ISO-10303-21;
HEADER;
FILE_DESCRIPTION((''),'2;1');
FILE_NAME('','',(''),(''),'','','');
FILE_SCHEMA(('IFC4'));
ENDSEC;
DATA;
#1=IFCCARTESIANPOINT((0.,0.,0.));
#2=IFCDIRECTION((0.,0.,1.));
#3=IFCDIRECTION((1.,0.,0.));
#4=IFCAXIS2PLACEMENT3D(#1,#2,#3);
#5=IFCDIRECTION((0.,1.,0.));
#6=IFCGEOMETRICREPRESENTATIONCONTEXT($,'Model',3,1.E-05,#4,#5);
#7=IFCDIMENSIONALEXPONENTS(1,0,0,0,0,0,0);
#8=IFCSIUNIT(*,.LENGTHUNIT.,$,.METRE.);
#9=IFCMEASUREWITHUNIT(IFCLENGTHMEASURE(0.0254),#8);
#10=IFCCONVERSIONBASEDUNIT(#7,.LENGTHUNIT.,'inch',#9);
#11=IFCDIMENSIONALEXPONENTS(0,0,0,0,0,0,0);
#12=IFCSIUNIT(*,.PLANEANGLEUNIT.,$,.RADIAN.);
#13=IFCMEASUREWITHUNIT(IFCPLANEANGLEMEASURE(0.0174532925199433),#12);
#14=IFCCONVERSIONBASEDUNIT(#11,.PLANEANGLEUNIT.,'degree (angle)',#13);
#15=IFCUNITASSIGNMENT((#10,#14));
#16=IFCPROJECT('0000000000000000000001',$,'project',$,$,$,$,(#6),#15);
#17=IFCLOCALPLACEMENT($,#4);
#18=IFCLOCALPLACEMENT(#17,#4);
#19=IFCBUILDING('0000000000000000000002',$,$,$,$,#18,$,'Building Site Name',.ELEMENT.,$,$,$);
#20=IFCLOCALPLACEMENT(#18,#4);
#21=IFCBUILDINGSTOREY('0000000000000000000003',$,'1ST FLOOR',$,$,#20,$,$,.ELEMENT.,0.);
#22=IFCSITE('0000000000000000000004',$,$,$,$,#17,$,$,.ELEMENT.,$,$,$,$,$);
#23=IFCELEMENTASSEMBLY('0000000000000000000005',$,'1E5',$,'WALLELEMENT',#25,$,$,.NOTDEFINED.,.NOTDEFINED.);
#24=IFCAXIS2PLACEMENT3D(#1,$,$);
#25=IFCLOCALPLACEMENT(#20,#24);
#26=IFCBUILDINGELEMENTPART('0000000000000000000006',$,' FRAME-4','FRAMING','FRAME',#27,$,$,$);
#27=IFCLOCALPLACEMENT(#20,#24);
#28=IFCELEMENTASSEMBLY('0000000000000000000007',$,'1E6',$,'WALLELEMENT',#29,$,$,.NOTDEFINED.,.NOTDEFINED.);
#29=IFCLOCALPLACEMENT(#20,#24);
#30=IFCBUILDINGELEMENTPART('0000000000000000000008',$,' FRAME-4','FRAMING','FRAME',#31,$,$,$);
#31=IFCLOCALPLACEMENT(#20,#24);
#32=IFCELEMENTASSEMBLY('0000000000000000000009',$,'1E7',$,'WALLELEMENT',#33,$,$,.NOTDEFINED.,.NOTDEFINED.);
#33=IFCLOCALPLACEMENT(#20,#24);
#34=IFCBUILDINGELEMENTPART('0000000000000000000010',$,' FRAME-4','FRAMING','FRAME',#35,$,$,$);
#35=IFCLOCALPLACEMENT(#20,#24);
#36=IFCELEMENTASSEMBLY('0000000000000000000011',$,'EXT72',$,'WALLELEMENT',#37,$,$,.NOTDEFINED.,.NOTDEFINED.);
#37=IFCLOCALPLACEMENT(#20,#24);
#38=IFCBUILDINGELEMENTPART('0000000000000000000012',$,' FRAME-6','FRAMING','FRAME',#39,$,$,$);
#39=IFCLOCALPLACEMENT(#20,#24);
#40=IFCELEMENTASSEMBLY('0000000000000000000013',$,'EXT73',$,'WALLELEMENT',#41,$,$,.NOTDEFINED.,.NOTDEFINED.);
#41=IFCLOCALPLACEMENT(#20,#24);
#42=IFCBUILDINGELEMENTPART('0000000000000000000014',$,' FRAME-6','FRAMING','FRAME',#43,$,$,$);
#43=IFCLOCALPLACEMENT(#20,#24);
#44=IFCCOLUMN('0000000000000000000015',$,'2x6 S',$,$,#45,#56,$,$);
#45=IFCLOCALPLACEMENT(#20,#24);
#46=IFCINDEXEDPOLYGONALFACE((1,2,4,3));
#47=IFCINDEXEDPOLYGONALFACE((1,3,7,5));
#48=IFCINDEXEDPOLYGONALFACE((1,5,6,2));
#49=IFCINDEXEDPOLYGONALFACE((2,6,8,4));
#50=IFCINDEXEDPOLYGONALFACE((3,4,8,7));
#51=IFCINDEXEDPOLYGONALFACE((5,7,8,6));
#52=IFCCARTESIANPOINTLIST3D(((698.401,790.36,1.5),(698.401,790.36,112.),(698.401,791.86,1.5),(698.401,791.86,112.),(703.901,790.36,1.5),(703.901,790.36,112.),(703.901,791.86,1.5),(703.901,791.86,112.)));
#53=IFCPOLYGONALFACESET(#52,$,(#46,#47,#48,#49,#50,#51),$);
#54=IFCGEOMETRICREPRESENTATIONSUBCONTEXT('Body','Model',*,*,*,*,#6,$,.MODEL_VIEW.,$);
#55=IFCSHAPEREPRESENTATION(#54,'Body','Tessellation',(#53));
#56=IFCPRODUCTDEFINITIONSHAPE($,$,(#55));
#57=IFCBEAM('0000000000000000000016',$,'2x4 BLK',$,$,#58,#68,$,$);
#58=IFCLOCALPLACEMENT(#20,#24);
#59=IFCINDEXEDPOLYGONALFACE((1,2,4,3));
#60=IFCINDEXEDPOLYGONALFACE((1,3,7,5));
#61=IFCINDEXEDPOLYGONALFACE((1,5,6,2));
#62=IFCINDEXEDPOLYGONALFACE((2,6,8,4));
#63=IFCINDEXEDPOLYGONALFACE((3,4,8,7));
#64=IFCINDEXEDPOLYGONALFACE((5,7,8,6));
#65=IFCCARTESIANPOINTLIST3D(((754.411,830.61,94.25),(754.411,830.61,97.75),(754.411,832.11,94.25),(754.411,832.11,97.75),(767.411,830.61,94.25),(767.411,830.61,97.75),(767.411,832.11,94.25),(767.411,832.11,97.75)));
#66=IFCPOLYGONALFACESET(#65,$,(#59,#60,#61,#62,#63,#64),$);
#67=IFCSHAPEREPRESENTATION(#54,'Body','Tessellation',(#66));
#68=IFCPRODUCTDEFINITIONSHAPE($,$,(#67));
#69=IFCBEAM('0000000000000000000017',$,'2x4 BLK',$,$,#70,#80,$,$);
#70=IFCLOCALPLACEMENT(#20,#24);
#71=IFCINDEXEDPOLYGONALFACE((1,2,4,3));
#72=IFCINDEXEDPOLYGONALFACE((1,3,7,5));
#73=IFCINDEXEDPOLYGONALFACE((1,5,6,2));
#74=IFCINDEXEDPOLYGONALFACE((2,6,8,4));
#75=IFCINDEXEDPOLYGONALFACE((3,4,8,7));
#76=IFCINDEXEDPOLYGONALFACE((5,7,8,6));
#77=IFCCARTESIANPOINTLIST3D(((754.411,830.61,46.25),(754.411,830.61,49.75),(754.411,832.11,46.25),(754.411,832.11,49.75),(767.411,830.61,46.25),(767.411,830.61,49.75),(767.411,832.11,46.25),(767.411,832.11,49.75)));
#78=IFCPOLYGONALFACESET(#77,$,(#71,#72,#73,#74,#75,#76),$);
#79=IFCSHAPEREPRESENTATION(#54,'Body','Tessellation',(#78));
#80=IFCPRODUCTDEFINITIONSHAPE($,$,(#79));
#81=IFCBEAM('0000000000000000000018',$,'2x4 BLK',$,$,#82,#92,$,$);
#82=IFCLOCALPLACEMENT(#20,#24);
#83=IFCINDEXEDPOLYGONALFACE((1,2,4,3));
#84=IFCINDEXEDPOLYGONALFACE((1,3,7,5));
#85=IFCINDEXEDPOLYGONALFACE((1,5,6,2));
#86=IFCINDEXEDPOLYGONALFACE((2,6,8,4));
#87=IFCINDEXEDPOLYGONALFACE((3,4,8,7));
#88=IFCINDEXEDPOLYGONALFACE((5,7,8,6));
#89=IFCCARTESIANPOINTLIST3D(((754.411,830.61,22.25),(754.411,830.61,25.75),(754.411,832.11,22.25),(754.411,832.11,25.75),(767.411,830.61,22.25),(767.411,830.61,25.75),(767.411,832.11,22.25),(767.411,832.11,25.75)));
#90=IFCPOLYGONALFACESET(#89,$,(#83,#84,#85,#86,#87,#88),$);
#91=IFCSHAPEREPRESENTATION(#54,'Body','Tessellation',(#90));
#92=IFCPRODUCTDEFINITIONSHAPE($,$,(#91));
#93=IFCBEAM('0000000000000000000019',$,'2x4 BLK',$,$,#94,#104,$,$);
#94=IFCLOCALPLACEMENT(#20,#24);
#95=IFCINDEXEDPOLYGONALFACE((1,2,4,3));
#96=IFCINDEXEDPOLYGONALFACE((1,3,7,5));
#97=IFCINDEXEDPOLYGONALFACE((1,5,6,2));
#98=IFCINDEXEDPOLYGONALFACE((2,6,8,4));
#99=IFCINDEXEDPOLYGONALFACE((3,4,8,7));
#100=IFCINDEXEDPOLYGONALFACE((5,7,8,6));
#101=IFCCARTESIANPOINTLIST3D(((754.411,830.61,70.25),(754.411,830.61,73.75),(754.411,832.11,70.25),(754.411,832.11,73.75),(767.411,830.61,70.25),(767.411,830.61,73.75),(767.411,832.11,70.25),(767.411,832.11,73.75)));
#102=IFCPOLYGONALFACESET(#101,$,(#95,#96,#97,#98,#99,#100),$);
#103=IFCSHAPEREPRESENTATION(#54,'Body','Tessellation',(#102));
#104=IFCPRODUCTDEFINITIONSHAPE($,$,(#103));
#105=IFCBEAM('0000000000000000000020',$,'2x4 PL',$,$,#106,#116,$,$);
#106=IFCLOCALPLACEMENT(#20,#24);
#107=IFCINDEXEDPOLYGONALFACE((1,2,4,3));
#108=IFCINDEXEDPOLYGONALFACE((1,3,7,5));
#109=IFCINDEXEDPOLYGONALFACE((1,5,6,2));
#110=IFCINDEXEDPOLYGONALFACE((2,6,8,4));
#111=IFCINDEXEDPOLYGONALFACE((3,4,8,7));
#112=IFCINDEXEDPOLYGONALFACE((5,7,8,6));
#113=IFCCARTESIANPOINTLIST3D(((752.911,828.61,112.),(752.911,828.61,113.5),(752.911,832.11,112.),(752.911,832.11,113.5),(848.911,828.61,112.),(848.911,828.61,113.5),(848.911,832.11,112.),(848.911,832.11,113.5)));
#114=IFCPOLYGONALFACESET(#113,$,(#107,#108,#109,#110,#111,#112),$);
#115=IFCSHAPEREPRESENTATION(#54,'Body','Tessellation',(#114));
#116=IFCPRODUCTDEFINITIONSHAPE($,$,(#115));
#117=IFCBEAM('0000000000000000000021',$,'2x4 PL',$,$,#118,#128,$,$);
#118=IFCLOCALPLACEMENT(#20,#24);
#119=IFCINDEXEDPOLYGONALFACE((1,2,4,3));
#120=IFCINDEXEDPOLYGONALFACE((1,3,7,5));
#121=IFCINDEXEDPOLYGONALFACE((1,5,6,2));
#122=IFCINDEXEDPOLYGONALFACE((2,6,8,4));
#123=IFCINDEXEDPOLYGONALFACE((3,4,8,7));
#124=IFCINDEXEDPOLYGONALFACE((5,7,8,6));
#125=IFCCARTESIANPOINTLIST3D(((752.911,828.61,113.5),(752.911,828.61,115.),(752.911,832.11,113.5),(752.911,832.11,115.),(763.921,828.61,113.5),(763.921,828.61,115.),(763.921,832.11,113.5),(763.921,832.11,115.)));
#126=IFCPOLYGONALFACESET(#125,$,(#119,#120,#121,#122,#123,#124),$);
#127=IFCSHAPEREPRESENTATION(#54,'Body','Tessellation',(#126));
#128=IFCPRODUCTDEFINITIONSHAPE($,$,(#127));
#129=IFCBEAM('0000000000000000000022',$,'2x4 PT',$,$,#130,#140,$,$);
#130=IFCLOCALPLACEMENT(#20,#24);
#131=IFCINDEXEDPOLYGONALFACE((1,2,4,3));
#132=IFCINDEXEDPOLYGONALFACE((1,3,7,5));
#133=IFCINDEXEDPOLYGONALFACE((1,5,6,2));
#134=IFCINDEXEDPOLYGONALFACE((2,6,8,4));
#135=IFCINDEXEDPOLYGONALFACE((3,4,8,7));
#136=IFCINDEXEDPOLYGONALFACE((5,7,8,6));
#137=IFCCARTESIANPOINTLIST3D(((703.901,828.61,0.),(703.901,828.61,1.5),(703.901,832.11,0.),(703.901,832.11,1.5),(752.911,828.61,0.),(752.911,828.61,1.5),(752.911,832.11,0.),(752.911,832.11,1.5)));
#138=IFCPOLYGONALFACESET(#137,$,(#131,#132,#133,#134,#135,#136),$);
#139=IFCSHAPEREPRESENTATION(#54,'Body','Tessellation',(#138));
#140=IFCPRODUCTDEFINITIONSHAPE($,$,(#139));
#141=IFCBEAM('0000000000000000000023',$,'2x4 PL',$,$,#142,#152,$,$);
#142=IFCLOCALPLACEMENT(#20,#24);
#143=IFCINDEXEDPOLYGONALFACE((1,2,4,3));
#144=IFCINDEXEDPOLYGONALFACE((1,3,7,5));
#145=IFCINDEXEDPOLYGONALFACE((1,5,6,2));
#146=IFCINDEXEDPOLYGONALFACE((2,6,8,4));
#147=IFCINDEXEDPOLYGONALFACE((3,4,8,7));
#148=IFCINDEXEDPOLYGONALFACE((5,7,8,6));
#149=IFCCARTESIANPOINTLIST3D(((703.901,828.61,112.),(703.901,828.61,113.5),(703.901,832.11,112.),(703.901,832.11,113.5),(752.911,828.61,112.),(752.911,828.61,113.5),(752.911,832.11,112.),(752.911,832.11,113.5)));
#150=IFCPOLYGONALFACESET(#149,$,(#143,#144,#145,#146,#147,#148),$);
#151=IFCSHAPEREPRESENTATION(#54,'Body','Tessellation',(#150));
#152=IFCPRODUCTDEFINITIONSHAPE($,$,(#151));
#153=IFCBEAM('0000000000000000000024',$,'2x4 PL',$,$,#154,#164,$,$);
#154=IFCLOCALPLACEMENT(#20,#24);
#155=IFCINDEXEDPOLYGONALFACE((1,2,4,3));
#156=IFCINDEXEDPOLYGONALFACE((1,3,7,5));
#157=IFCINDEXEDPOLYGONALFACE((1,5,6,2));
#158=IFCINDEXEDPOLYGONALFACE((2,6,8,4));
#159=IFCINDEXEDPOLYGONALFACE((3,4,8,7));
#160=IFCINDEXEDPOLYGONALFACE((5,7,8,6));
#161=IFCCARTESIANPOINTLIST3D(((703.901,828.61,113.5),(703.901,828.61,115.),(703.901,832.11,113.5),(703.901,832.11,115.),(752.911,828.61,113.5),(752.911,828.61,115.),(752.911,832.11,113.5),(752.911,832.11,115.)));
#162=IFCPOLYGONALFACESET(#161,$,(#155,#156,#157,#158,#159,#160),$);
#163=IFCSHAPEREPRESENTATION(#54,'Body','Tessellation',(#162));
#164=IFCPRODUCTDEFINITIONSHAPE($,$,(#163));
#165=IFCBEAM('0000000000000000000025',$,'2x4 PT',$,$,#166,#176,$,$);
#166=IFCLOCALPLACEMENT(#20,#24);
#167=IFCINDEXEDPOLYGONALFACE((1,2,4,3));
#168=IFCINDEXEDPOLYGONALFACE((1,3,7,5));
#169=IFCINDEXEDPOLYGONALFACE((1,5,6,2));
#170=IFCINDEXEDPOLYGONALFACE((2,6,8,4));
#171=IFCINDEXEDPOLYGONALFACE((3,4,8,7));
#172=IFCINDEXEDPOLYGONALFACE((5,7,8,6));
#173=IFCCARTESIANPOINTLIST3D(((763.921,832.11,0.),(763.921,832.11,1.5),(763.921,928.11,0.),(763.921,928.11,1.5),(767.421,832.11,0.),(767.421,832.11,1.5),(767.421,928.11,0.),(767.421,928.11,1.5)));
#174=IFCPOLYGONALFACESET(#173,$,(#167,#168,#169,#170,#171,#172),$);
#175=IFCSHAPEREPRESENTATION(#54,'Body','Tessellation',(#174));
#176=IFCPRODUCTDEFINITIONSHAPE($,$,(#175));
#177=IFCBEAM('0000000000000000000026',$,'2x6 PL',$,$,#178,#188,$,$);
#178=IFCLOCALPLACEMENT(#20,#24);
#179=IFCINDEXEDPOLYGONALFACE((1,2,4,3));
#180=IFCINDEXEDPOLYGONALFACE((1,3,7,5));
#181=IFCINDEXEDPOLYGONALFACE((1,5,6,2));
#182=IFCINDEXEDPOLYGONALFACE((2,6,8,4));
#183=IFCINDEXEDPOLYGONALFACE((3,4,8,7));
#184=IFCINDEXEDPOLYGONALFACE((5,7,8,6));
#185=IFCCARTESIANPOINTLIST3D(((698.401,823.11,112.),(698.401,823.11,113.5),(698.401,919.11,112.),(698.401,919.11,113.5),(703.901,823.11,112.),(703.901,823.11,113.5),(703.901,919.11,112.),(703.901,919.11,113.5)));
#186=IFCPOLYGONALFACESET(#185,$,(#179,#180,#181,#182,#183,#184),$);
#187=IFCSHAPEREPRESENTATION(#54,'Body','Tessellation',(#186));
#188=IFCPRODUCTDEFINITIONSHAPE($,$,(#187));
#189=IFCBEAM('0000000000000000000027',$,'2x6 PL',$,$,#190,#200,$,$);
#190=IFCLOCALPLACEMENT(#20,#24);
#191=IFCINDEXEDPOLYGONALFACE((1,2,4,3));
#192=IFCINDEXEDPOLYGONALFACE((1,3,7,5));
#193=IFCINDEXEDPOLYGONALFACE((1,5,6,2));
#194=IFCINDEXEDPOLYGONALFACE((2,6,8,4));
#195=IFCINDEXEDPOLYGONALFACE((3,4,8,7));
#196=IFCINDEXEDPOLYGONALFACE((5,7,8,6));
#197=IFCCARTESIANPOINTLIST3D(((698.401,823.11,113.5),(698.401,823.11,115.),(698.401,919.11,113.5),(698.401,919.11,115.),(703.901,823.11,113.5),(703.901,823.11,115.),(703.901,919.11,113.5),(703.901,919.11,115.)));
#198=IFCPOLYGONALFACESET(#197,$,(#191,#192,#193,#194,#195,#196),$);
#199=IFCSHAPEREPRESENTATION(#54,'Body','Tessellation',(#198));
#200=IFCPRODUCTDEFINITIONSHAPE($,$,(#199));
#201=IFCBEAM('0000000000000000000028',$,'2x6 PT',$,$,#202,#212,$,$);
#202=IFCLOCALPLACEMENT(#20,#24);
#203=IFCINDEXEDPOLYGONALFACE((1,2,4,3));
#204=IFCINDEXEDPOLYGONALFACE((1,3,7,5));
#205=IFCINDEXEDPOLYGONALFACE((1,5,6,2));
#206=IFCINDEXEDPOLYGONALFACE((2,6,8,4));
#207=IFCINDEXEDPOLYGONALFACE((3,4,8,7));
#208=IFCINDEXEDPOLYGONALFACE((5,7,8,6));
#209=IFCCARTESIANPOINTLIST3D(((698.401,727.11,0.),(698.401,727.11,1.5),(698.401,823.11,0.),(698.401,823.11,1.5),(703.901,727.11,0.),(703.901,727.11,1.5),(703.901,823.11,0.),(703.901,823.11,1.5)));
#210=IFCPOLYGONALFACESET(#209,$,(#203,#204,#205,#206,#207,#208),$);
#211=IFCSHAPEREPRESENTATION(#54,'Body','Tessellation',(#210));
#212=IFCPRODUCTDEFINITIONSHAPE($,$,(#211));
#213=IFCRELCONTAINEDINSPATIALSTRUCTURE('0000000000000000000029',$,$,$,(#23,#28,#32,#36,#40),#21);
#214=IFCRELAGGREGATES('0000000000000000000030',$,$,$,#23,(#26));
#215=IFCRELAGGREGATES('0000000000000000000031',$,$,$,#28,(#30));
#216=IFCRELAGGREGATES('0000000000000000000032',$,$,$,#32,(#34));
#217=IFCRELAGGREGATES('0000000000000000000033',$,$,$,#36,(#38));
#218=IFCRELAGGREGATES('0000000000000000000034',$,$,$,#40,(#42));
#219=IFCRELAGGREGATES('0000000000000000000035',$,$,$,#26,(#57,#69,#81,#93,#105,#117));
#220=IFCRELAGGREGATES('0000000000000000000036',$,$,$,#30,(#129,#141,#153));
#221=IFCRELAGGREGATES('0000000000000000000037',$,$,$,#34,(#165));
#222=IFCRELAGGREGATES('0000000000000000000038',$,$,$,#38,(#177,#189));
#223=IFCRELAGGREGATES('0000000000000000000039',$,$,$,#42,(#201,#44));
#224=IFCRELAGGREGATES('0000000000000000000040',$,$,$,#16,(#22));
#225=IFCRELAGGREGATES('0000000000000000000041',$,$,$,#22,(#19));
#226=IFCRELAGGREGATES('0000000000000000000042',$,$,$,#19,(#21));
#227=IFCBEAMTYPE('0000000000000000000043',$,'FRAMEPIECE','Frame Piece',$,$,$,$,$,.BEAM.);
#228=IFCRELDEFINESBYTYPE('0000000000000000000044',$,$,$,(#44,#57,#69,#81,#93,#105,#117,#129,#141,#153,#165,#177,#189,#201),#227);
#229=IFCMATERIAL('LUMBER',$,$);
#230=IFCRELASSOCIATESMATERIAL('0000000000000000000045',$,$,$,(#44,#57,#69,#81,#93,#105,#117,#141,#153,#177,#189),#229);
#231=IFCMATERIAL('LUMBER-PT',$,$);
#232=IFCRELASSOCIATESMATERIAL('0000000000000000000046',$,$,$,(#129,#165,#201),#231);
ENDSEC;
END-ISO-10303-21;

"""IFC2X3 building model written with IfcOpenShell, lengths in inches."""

from ifc_helpers import new_model, entity, si_unit, converted_unit, direction, frame, frame_2d, origin_with_axes, place, context, subcontext, project, spatial, rectangle, extrude, material, type_object, element, aggregate, save


model = new_model("IFC2X3")

# Units and contexts
model_context = context("Model", 3, precision=1e-05, world=origin_with_axes(), true_north=direction((0.0, 1.0, 0.0)))
body_context = subcontext(model_context, "Body", "Model", "MODEL_VIEW")
ifc_project = project(units=[converted_unit("LENGTHUNIT", "inch", entity("IfcLengthMeasure", 0.0254), si_unit("LENGTHUNIT", "METRE"), dimensions=[1, 0, 0, 0, 0, 0, 0]), converted_unit("PLANEANGLEUNIT", "degree (angle)", entity("IfcPlaneAngleMeasure", 0.0174532925199433), si_unit("PLANEANGLEUNIT", "RADIAN"), dimensions=[0, 0, 0, 0, 0, 0, 0])], contexts=[model_context])

# Site, building, storey
site_placement = place(None, origin_with_axes())
site = spatial("IfcSite", under=ifc_project, at=site_placement, CompositionType="ELEMENT")
building_placement = place(site_placement, origin_with_axes())
building = spatial("IfcBuilding", under=site, at=building_placement, LongName="Building Site Name", CompositionType="ELEMENT")
storey_placement = place(building_placement, origin_with_axes())
storey = spatial("IfcBuildingStorey", under=building, at=storey_placement, Name="1ST FLOOR", CompositionType="ELEMENT", Elevation=0.0)

# Element assembly, building element part
assembly_1_placement = place(storey_placement, origin_with_axes())
assembly_1 = element("IfcElementAssembly", 1, at=assembly_1_placement, inside=storey, Name="1E5", ObjectType="WALLELEMENT", AssemblyPlace="NOTDEFINED", PredefinedType="NOTDEFINED")
building_element_part_1 = element("IfcBuildingElementPart", 2, Name=" FRAME-4", Description="FRAMING", ObjectType="FRAME")
aggregate(assembly_1, [building_element_part_1])
ifc_material_1 = material(Name="LUMBER")
beam_type = type_object("IfcBeamType", Name="FRAMEPIECE", Description="Frame Piece", PredefinedType="BEAM")

# Element assemblies, building element parts, column
assembly_2_placement = place(storey_placement, origin_with_axes())
assembly_2 = element("IfcElementAssembly", 3, at=assembly_2_placement, inside=storey, Name="1E6", ObjectType="WALLELEMENT", AssemblyPlace="NOTDEFINED", PredefinedType="NOTDEFINED")
building_element_part_2 = element("IfcBuildingElementPart", 4, Name=" FRAME-4", Description="FRAMING", ObjectType="FRAME")
aggregate(assembly_2, [building_element_part_2])
assembly_3_placement = place(storey_placement, origin_with_axes())
assembly_3 = element("IfcElementAssembly", 5, at=assembly_3_placement, inside=storey, Name="1E7", ObjectType="WALLELEMENT", AssemblyPlace="NOTDEFINED", PredefinedType="NOTDEFINED")
building_element_part_3 = element("IfcBuildingElementPart", 6, Name=" FRAME-4", Description="FRAMING", ObjectType="FRAME")
aggregate(assembly_3, [building_element_part_3])
assembly_4_placement = place(storey_placement, origin_with_axes())
assembly_4 = element("IfcElementAssembly", 7, at=assembly_4_placement, inside=storey, Name="EXT72", ObjectType="WALLELEMENT", AssemblyPlace="NOTDEFINED", PredefinedType="NOTDEFINED")
building_element_part_4 = element("IfcBuildingElementPart", 8, Name=" FRAME-6", Description="FRAMING", ObjectType="FRAME")
aggregate(assembly_4, [building_element_part_4])
assembly_5_placement = place(storey_placement, origin_with_axes())
assembly_5 = element("IfcElementAssembly", 9, at=assembly_5_placement, inside=storey, Name="EXT73", ObjectType="WALLELEMENT", AssemblyPlace="NOTDEFINED", PredefinedType="NOTDEFINED")
building_element_part_5 = element("IfcBuildingElementPart", 10, Name=" FRAME-6", Description="FRAMING", ObjectType="FRAME")
aggregate(assembly_5, [building_element_part_5])
column_1_placement = place(assembly_5_placement, frame((701.151, 791.11, 112.0), z_axis=(0.0, 0.0, -1.0), x_axis=(0.0, -1.0, 0.0)))
column_1 = element("IfcColumn", 11, at=column_1_placement, type_object=beam_type, material=ifc_material_1, Name="2x6 S", context=body_context, shape_type="SweptSolid", body=[
    extrude(rectangle(XDim=1.5, YDim=5.5, at=frame_2d((0.0, 0.0), x_axis=(-1.0, 0.0))), origin_with_axes(), (0.0, 0.0, 1.0), 110.5),
])

# Beams
beam_1_placement = place(assembly_1_placement, frame((754.411, 831.36, 96.0), z_axis=(1.0, 0.0, 0.0), x_axis=(0.0, -1.0, 0.0)))
beam_1 = element("IfcBeam", 12, at=beam_1_placement, type_object=beam_type, material=ifc_material_1, Name="2x4 BLK", context=body_context, shape_type="SweptSolid", body=[
    extrude(rectangle(XDim=1.5, YDim=3.5, at=frame_2d((0.0, 0.0), x_axis=(-1.0, 0.0))), origin_with_axes(), (0.0, 0.0, 1.0), 13.0),
])
beam_2_placement = place(assembly_1_placement, frame((754.411, 831.36, 48.0), z_axis=(1.0, 0.0, 0.0), x_axis=(0.0, -1.0, 0.0)))
beam_2 = element("IfcBeam", 13, at=beam_2_placement, type_object=beam_type, material=ifc_material_1, Name="2x4 BLK", context=body_context, shape_type="SweptSolid", body=[
    extrude(rectangle(XDim=1.5, YDim=3.5, at=frame_2d((0.0, 0.0), x_axis=(-1.0, 0.0))), origin_with_axes(), (0.0, 0.0, 1.0), 13.0),
])
beam_3_placement = place(assembly_1_placement, frame((754.411, 831.36, 24.0), z_axis=(1.0, 0.0, 0.0), x_axis=(0.0, -1.0, 0.0)))
beam_3 = element("IfcBeam", 14, at=beam_3_placement, type_object=beam_type, material=ifc_material_1, Name="2x4 BLK", context=body_context, shape_type="SweptSolid", body=[
    extrude(rectangle(XDim=1.5, YDim=3.5, at=frame_2d((0.0, 0.0), x_axis=(-1.0, 0.0))), origin_with_axes(), (0.0, 0.0, 1.0), 13.0),
])
beam_4_placement = place(assembly_1_placement, frame((754.411, 831.36, 72.0), z_axis=(1.0, 0.0, 0.0), x_axis=(0.0, -1.0, 0.0)))
beam_4 = element("IfcBeam", 15, at=beam_4_placement, type_object=beam_type, material=ifc_material_1, Name="2x4 BLK", context=body_context, shape_type="SweptSolid", body=[
    extrude(rectangle(XDim=1.5, YDim=3.5, at=frame_2d((0.0, 0.0), x_axis=(-1.0, 0.0))), origin_with_axes(), (0.0, 0.0, 1.0), 13.0),
])
beam_5_placement = place(assembly_1_placement, frame((752.911, 830.36, 112.75), z_axis=(1.0, 0.0, 0.0), x_axis=(0.0, 0.0, -1.0)))
beam_5 = element("IfcBeam", 16, at=beam_5_placement, type_object=beam_type, material=ifc_material_1, Name="2x4 PL", context=body_context, shape_type="SweptSolid", body=[
    extrude(rectangle(XDim=1.5, YDim=3.5, at=frame_2d((0.0, 0.0), x_axis=(-1.0, 0.0))), origin_with_axes(), (0.0, 0.0, 1.0), 96.0),
])
beam_6_placement = place(assembly_1_placement, frame((752.911, 830.36, 114.25), z_axis=(1.0, 0.0, 0.0), x_axis=(0.0, 0.0, -1.0)))
beam_6 = element("IfcBeam", 17, at=beam_6_placement, type_object=beam_type, material=ifc_material_1, Name="2x4 PL", context=body_context, shape_type="SweptSolid", body=[
    extrude(rectangle(XDim=1.5, YDim=3.5, at=frame_2d((0.0, 0.0), x_axis=(-1.0, 0.0))), origin_with_axes(), (0.0, 0.0, 1.0), 11.01),
])
aggregate(building_element_part_1, [beam_1, beam_2, beam_3, beam_4, beam_5, beam_6])
ifc_material_2 = material(Name="LUMBER-PT")
beam_7_placement = place(assembly_2_placement, frame((752.911, 830.36, 0.75), z_axis=(-1.0, 0.0, 0.0), x_axis=(0.0, 0.0, 1.0)))
beam_7 = element("IfcBeam", 18, at=beam_7_placement, type_object=beam_type, material=ifc_material_2, Name="2x4 PT", context=body_context, shape_type="SweptSolid", body=[
    extrude(rectangle(XDim=1.5, YDim=3.5, at=frame_2d((0.0, 0.0), x_axis=(-1.0, 0.0))), frame((0.0, 0.0, 0.0), z_axis=(0.0, 0.0, 1.0), x_axis=(1.0, 0.0, 0.0)), (0.0, 0.0, 1.0), 49.01),
])
beam_8_placement = place(assembly_2_placement, frame((703.901, 830.36, 112.75), z_axis=(1.0, 0.0, 0.0), x_axis=(0.0, 0.0, -1.0)))
beam_8 = element("IfcBeam", 19, at=beam_8_placement, type_object=beam_type, material=ifc_material_1, Name="2x4 PL", context=body_context, shape_type="SweptSolid", body=[
    extrude(rectangle(XDim=1.5, YDim=3.5, at=frame_2d((0.0, 0.0), x_axis=(-1.0, 0.0))), frame((0.0, 0.0, 0.0), z_axis=(0.0, 0.0, 1.0), x_axis=(1.0, 0.0, 0.0)), (0.0, 0.0, 1.0), 49.01),
])
beam_9_placement = place(assembly_2_placement, frame((703.901, 830.36, 114.25), z_axis=(1.0, 0.0, 0.0), x_axis=(0.0, 0.0, -1.0)))
beam_9 = element("IfcBeam", 20, at=beam_9_placement, type_object=beam_type, material=ifc_material_1, Name="2x4 PL", context=body_context, shape_type="SweptSolid", body=[
    extrude(rectangle(XDim=1.5, YDim=3.5, at=frame_2d((0.0, 0.0), x_axis=(-1.0, 0.0))), origin_with_axes(), (0.0, 0.0, 1.0), 49.01),
])
aggregate(building_element_part_2, [beam_7, beam_8, beam_9])
beam_10_placement = place(assembly_3_placement, frame((765.671, 832.11, 0.75), z_axis=(0.0, 1.0, 0.0), x_axis=(0.0, 0.0, 1.0)))
beam_10 = element("IfcBeam", 21, at=beam_10_placement, type_object=beam_type, material=ifc_material_2, Name="2x4 PT", context=body_context, shape_type="SweptSolid", body=[
    extrude(rectangle(XDim=1.5, YDim=3.5, at=frame_2d((0.0, 0.0), x_axis=(-1.0, 0.0))), origin_with_axes(), (0.0, 0.0, 1.0), 96.0),
])
aggregate(building_element_part_3, [beam_10])
beam_11_placement = place(assembly_4_placement, frame((701.151, 823.11, 112.75), z_axis=(0.0, 1.0, 0.0), x_axis=(0.0, 0.0, -1.0)))
beam_11 = element("IfcBeam", 22, at=beam_11_placement, type_object=beam_type, material=ifc_material_1, Name="2x6 PL", context=body_context, shape_type="SweptSolid", body=[
    extrude(rectangle(XDim=1.5, YDim=5.5, at=frame_2d((0.0, 0.0), x_axis=(-1.0, 0.0))), origin_with_axes(), (0.0, 0.0, 1.0), 96.0),
])
beam_12_placement = place(assembly_4_placement, frame((701.151, 823.11, 114.25), z_axis=(0.0, 1.0, 0.0), x_axis=(0.0, 0.0, -1.0)))
beam_12 = element("IfcBeam", 23, at=beam_12_placement, type_object=beam_type, material=ifc_material_1, Name="2x6 PL", context=body_context, shape_type="SweptSolid", body=[
    extrude(rectangle(XDim=1.5, YDim=5.5, at=frame_2d((0.0, 0.0), x_axis=(-1.0, 0.0))), origin_with_axes(), (0.0, 0.0, 1.0), 96.0),
])
aggregate(building_element_part_4, [beam_11, beam_12])
beam_13_placement = place(assembly_5_placement, frame((701.151, 823.11, 0.75), z_axis=(0.0, -1.0, 0.0), x_axis=(0.0, 0.0, 1.0)))
beam_13 = element("IfcBeam", 24, at=beam_13_placement, type_object=beam_type, material=ifc_material_2, Name="2x6 PT", context=body_context, shape_type="SweptSolid", body=[
    extrude(rectangle(XDim=1.5, YDim=5.5, at=frame_2d((0.0, 0.0), x_axis=(-1.0, 0.0))), origin_with_axes(), (0.0, 0.0, 1.0), 96.0),
])
aggregate(building_element_part_5, [beam_13, column_1])

save(model, "model.ifc")
